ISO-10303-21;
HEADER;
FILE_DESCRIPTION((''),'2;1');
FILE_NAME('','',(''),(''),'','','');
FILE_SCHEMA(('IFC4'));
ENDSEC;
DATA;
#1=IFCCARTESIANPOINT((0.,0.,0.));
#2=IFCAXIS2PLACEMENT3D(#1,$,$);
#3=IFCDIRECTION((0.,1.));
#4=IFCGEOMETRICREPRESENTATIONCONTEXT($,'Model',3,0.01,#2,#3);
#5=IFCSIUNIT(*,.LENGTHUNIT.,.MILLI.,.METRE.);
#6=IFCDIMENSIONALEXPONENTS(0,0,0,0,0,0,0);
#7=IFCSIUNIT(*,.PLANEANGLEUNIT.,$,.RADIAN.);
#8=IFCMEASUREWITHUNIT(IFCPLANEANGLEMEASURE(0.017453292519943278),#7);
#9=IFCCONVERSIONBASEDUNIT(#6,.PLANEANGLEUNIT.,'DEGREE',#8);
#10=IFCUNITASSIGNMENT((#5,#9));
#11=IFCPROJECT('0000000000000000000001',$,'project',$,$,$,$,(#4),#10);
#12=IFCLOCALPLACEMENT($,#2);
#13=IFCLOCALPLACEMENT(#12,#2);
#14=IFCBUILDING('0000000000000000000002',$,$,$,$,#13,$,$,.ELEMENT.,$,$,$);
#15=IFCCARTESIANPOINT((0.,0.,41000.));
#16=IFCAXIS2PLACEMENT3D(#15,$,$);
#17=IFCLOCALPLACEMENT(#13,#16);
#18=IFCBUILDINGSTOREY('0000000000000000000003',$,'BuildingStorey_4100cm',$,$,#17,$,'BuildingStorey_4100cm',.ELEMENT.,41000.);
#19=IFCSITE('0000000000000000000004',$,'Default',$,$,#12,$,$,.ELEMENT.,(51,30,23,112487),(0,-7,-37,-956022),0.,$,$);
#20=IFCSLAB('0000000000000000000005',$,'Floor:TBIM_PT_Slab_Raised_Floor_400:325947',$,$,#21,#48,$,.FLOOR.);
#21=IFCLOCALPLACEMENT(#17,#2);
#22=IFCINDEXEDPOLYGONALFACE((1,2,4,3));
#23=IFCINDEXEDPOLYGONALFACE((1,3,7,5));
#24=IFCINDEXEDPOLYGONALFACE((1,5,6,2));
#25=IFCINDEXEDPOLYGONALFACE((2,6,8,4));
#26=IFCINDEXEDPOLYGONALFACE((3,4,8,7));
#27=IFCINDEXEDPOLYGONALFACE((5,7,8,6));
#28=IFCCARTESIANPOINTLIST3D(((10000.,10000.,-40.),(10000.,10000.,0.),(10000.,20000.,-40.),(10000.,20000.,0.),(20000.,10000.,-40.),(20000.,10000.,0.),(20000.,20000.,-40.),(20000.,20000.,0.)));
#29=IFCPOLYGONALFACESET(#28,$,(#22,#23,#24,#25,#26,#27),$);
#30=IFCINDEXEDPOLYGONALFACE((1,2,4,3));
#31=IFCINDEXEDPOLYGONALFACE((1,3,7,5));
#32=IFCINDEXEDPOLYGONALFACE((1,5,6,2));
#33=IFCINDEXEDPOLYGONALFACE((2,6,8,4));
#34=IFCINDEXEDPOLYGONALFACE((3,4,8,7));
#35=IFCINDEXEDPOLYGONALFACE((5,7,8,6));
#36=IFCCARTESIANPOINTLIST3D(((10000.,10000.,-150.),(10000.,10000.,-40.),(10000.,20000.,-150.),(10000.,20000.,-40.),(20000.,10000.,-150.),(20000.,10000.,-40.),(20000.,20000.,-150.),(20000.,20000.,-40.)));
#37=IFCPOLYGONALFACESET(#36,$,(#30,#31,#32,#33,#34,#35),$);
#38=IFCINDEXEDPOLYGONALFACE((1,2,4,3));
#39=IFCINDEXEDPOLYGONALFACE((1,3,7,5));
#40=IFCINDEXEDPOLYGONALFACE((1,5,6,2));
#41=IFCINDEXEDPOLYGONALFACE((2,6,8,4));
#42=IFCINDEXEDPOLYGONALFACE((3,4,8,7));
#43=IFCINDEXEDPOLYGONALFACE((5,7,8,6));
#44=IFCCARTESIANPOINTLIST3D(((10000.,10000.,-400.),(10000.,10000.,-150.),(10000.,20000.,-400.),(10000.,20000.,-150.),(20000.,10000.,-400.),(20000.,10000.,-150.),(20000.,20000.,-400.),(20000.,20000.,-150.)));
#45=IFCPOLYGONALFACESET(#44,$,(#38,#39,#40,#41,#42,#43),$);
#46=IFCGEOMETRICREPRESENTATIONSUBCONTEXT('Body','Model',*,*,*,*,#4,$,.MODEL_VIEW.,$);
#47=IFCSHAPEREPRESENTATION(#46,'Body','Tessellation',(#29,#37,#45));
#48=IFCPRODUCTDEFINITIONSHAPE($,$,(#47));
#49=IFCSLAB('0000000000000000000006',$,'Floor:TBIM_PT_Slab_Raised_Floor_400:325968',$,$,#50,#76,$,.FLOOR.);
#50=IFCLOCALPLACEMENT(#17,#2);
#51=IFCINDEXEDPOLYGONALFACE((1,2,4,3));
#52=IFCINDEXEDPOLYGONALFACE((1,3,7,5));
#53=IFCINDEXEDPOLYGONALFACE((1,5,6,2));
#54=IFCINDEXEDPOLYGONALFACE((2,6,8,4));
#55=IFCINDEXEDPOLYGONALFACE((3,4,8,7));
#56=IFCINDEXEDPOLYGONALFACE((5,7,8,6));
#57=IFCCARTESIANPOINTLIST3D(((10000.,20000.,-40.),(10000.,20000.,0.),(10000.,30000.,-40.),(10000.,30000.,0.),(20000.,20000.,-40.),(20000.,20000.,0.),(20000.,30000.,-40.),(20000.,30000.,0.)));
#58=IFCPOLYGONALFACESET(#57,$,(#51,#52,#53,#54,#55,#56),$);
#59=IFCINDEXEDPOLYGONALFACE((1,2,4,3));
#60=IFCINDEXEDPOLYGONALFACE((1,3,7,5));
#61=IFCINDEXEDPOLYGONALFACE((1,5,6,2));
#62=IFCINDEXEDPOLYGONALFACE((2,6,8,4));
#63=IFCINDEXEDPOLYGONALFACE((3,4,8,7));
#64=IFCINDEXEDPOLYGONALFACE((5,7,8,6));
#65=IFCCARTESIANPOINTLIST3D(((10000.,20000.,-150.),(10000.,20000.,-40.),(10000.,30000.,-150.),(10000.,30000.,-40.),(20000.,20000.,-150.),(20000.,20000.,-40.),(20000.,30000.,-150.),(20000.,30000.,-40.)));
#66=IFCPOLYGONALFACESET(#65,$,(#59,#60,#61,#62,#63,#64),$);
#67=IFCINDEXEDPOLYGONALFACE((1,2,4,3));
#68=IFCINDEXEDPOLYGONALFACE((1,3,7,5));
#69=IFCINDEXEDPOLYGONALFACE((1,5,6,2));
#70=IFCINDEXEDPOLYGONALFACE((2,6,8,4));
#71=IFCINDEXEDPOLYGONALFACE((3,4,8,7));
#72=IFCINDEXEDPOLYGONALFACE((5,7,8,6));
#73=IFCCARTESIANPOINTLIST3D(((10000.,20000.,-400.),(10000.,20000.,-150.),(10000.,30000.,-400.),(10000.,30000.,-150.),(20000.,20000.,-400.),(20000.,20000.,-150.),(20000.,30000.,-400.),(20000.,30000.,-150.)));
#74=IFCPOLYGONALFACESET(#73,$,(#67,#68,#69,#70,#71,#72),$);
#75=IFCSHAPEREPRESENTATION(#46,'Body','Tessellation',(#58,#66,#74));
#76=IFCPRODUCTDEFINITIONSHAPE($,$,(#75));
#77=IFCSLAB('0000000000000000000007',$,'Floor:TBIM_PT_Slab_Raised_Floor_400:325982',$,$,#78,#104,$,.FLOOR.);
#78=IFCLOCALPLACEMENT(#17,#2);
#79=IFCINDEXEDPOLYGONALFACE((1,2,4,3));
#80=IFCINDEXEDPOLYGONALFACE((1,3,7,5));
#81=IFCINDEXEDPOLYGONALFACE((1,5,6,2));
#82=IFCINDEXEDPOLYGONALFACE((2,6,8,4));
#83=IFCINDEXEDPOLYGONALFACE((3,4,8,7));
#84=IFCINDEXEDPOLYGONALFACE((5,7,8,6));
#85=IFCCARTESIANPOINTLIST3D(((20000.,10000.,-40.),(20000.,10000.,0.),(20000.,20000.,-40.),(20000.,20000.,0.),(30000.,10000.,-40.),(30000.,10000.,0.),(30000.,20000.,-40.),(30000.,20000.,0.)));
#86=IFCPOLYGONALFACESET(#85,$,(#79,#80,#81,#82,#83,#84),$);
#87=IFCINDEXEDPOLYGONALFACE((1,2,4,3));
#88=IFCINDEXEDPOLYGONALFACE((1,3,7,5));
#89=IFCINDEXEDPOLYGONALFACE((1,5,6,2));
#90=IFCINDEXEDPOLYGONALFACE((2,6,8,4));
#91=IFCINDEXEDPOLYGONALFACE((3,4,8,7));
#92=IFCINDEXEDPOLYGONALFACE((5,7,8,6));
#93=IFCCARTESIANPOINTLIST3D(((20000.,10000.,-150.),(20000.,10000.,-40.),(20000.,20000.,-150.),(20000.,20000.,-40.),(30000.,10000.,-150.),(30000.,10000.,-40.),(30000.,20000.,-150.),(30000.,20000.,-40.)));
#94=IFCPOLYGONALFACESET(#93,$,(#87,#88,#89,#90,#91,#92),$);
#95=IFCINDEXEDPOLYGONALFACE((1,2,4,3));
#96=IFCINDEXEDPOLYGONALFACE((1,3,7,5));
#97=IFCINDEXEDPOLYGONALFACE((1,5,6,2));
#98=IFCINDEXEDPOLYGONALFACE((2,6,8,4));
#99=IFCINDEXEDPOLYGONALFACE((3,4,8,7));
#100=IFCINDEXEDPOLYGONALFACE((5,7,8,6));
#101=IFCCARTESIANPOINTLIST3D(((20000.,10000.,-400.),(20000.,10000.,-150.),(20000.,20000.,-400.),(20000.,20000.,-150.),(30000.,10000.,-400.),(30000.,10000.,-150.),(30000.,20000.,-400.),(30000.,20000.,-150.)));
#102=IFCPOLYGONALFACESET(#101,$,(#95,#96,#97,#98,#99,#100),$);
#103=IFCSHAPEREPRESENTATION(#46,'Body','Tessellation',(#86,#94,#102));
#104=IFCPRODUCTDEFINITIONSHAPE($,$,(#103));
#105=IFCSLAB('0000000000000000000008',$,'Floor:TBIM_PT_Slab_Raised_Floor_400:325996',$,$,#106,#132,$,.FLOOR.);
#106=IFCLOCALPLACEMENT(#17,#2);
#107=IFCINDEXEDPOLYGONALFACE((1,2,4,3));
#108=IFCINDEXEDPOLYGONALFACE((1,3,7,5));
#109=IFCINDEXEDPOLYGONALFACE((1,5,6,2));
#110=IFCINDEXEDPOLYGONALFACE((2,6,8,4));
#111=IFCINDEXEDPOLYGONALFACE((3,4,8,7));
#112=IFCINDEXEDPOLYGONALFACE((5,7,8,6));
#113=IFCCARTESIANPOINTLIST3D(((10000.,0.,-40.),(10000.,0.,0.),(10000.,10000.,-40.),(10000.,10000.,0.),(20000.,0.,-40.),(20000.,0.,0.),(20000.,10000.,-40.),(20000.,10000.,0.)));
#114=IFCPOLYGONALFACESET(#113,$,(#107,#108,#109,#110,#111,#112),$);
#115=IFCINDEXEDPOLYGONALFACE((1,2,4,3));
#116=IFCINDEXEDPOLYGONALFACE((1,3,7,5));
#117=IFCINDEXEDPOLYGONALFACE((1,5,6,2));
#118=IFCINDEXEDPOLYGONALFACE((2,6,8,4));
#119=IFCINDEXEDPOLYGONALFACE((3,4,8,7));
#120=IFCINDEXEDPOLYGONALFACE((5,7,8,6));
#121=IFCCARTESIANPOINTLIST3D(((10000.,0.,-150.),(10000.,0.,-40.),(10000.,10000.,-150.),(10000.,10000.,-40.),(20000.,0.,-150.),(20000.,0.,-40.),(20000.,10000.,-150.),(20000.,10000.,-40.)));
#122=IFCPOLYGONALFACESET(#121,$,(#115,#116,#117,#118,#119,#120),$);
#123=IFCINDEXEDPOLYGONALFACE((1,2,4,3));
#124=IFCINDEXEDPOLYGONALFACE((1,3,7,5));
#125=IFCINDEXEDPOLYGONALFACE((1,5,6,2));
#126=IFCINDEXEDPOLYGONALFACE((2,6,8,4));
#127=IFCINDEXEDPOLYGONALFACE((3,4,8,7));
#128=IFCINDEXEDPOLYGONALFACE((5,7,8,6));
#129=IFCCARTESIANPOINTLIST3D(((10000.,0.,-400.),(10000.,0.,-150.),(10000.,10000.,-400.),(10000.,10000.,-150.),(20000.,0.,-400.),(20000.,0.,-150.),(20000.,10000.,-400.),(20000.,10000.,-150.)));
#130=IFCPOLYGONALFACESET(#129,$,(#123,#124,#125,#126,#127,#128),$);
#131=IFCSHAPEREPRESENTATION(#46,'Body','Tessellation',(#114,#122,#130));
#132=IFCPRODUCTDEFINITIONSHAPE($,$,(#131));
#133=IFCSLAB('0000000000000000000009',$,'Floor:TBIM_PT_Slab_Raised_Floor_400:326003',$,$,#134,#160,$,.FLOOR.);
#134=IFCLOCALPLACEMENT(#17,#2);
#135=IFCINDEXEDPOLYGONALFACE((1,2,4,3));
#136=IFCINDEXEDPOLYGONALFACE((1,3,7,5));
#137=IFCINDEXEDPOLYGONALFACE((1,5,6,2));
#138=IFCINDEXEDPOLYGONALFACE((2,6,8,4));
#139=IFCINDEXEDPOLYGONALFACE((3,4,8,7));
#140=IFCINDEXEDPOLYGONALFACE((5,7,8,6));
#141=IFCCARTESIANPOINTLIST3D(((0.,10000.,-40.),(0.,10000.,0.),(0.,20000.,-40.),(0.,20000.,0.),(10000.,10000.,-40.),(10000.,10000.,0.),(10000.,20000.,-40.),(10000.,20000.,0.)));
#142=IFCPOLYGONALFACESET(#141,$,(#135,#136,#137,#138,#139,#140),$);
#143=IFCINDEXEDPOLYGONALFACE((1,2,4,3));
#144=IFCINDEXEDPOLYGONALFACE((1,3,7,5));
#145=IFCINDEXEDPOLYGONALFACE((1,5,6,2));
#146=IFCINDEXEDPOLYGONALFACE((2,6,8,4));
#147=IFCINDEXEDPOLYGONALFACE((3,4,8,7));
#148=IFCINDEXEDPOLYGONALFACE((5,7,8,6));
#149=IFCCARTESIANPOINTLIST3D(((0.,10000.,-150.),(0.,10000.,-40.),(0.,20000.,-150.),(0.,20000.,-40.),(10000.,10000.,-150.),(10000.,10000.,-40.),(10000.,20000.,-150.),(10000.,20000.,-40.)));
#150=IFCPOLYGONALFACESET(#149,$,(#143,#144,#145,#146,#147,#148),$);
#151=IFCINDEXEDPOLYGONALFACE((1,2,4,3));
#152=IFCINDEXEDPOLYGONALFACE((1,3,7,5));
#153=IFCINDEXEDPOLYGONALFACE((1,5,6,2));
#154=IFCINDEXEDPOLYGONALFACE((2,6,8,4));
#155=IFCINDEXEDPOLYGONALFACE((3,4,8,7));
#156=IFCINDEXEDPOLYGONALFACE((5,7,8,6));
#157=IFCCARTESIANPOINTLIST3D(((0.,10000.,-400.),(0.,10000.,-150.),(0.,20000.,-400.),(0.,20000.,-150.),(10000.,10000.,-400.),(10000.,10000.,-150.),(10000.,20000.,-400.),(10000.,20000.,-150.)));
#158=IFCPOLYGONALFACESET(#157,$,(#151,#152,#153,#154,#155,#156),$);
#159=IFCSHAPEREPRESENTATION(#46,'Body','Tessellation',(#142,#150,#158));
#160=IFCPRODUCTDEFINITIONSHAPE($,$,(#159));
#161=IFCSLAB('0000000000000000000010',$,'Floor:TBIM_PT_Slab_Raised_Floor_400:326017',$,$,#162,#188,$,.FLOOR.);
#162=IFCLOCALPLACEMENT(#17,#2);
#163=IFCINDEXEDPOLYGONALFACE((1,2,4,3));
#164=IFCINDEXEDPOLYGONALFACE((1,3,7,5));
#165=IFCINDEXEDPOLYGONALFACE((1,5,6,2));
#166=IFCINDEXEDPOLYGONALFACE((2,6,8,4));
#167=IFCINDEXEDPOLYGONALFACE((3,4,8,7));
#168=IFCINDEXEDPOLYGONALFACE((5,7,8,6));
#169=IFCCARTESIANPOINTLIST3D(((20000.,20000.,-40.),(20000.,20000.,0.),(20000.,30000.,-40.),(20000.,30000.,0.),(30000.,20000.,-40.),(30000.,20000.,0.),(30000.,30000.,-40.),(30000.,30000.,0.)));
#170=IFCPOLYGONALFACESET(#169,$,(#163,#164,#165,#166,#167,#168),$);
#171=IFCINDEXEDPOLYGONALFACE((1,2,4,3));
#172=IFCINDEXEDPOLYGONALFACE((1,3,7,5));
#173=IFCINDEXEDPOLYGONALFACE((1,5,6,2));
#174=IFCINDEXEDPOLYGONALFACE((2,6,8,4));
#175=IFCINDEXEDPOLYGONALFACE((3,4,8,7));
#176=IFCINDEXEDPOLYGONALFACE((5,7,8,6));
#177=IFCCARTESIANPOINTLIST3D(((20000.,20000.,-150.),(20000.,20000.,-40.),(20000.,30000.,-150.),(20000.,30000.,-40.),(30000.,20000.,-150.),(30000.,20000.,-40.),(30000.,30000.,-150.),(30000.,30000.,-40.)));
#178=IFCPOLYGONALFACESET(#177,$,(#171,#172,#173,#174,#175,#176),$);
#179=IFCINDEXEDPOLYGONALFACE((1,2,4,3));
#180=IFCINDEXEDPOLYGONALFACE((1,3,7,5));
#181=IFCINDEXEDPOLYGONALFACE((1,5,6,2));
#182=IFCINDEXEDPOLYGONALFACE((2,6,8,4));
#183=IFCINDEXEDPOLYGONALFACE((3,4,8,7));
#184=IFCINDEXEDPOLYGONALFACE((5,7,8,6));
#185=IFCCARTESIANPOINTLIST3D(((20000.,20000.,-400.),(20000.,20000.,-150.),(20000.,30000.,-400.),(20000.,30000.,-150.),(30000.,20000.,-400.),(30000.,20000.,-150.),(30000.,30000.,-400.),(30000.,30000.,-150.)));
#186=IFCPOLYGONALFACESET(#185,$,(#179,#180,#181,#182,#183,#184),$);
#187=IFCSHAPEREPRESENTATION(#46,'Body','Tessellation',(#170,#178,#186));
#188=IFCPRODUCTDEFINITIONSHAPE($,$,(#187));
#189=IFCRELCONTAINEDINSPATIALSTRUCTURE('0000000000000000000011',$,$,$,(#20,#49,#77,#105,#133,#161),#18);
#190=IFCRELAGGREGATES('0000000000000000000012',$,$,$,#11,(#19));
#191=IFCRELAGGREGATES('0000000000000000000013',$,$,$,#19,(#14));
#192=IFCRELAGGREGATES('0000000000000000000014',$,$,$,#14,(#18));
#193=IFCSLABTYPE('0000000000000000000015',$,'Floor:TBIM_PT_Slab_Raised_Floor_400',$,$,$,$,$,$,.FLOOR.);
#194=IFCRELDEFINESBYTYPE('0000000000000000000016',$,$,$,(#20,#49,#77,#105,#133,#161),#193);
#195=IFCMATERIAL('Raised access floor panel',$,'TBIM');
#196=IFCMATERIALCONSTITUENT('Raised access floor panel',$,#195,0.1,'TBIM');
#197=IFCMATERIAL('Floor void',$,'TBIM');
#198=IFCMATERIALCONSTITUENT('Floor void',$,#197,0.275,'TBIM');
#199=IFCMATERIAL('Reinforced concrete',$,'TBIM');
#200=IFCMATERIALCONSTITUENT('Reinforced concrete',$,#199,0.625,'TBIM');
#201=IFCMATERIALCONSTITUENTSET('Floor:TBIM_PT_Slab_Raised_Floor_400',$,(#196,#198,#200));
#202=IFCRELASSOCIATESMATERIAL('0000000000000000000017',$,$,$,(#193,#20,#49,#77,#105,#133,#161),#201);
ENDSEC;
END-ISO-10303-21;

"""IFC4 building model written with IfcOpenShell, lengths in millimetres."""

from ifc_helpers import new_model, entity, si_unit, converted_unit, direction, frame, origin, place, context, subcontext, project, spatial, indexed_curve, outline, extrude, material, constituent, constituent_set, type_object, element, save


model = new_model("IFC4")

# Units and contexts
model_context = context("Model", 3, precision=0.01, world=origin(), true_north=direction((0.0, 1.0)))
body_context = subcontext(model_context, "Body", "Model", "MODEL_VIEW")
ifc_project = project(units=[si_unit("LENGTHUNIT", "METRE", prefix="MILLI"), converted_unit("PLANEANGLEUNIT", "DEGREE", entity("IfcPlaneAngleMeasure", 0.017453292519943278), si_unit("PLANEANGLEUNIT", "RADIAN"), dimensions=[0, 0, 0, 0, 0, 0, 0])], contexts=[model_context])

# Site, building, storey
site_placement = place(None, origin())
site = spatial("IfcSite", under=ifc_project, at=site_placement, Name="Default", CompositionType="ELEMENT", RefLatitude=(51, 30, 23, 112487), RefLongitude=(0, -7, -37, -956022), RefElevation=0.0)
building_placement = place(site_placement, origin())
building = spatial("IfcBuilding", under=site, at=building_placement, CompositionType="ELEMENT")
storey_placement = place(building_placement, frame((0.0, 0.0, 41000.0)))
storey = spatial("IfcBuildingStorey", under=building, at=storey_placement, Name="BuildingStorey_4100cm", LongName="BuildingStorey_4100cm", CompositionType="ELEMENT", Elevation=41000.0)

# Slabs
ifc_material_1 = material(Name="Raised access floor panel", Category="TBIM")
ifc_constituent_1 = constituent(ifc_material_1, Name="Raised access floor panel", Category="TBIM", fraction=0.1)
ifc_material_2 = material(Name="Floor void", Category="TBIM")
ifc_constituent_2 = constituent(ifc_material_2, Name="Floor void", Category="TBIM", fraction=0.275)
ifc_material_3 = material(Name="Reinforced concrete", Category="TBIM")
ifc_constituent_3 = constituent(ifc_material_3, Name="Reinforced concrete", Category="TBIM", fraction=0.625)
ifc_constituent_set_1 = constituent_set(constituents=[ifc_constituent_1, ifc_constituent_2, ifc_constituent_3], Name="Floor:TBIM_PT_Slab_Raised_Floor_400")
slab_type = type_object("IfcSlabType", Name="Floor:TBIM_PT_Slab_Raised_Floor_400", PredefinedType="FLOOR", material=ifc_constituent_set_1)
slab_1_placement = place(storey_placement, origin())
element("IfcSlab", 1, at=slab_1_placement, inside=storey, type_object=slab_type, material=ifc_constituent_set_1, Name="Floor:TBIM_PT_Slab_Raised_Floor_400:325947", PredefinedType="FLOOR", context=body_context, shape_type="SweptSolid", body=[
    extrude(outline(indexed_curve([(-5000.0, -5000.0), (5000.0, -5000.0), (5000.0, 5000.0), (-5000.0, 5000.0), (-5000.0, -5000.0)], self_intersect=False)), frame((15000.0, 15000.0, -40.0), z_axis=(0.0, 0.0, 1.0), x_axis=(-1.0, 0.0, 0.0)), (0.0, 0.0, 1.0), 40.0),
    extrude(outline(indexed_curve([(-5000.0, -5000.0), (5000.0, -5000.0), (5000.0, 5000.0), (-5000.0, 5000.0), (-5000.0, -5000.0)], self_intersect=False)), frame((15000.0, 15000.0, -150.0), z_axis=(0.0, 0.0, 1.0), x_axis=(-1.0, 0.0, 0.0)), (0.0, 0.0, 1.0), 110.0),
    extrude(outline(indexed_curve([(-5000.0, -5000.0), (5000.0, -5000.0), (5000.0, 5000.0), (-5000.0, 5000.0), (-5000.0, -5000.0)], self_intersect=False)), frame((15000.0, 15000.0, -400.0), z_axis=(0.0, 0.0, 1.0), x_axis=(-1.0, 0.0, 0.0)), (0.0, 0.0, 1.0), 250.0),
])
slab_2_placement = place(storey_placement, origin())
element("IfcSlab", 2, at=slab_2_placement, inside=storey, type_object=slab_type, material=ifc_constituent_set_1, Name="Floor:TBIM_PT_Slab_Raised_Floor_400:325968", PredefinedType="FLOOR", context=body_context, shape_type="SweptSolid", body=[
    extrude(outline(indexed_curve([(-5000.0, -5000.0), (5000.0, -5000.0), (5000.0, 5000.0), (-5000.0, 5000.0), (-5000.0, -5000.0)], self_intersect=False)), frame((15000.0, 25000.0, -40.0), z_axis=(0.0, 0.0, 1.0), x_axis=(-1.0, 0.0, 0.0)), (0.0, 0.0, 1.0), 40.0),
    extrude(outline(indexed_curve([(-5000.0, -5000.0), (5000.0, -5000.0), (5000.0, 5000.0), (-5000.0, 5000.0), (-5000.0, -5000.0)], self_intersect=False)), frame((15000.0, 25000.0, -150.0), z_axis=(0.0, 0.0, 1.0), x_axis=(-1.0, 0.0, 0.0)), (0.0, 0.0, 1.0), 110.0),
    extrude(outline(indexed_curve([(-5000.0, -5000.0), (5000.0, -5000.0), (5000.0, 5000.0), (-5000.0, 5000.0), (-5000.0, -5000.0)], self_intersect=False)), frame((15000.0, 25000.0, -400.0), z_axis=(0.0, 0.0, 1.0), x_axis=(-1.0, 0.0, 0.0)), (0.0, 0.0, 1.0), 250.0),
])
slab_3_placement = place(storey_placement, origin())
element("IfcSlab", 3, at=slab_3_placement, inside=storey, type_object=slab_type, material=ifc_constituent_set_1, Name="Floor:TBIM_PT_Slab_Raised_Floor_400:325982", PredefinedType="FLOOR", context=body_context, shape_type="SweptSolid", body=[
    extrude(outline(indexed_curve([(-5000.0, -5000.0), (5000.0, -5000.0), (5000.0, 5000.0), (-5000.0, 5000.0), (-5000.0, -5000.0)], self_intersect=False)), frame((25000.0, 15000.0, -40.0), z_axis=(0.0, 0.0, 1.0), x_axis=(-1.0, 0.0, 0.0)), (0.0, 0.0, 1.0), 40.0),
    extrude(outline(indexed_curve([(-5000.0, -5000.0), (5000.0, -5000.0), (5000.0, 5000.0), (-5000.0, 5000.0), (-5000.0, -5000.0)], self_intersect=False)), frame((25000.0, 15000.0, -150.0), z_axis=(0.0, 0.0, 1.0), x_axis=(-1.0, 0.0, 0.0)), (0.0, 0.0, 1.0), 110.0),
    extrude(outline(indexed_curve([(-5000.0, -5000.0), (5000.0, -5000.0), (5000.0, 5000.0), (-5000.0, 5000.0), (-5000.0, -5000.0)], self_intersect=False)), frame((25000.0, 15000.0, -400.0), z_axis=(0.0, 0.0, 1.0), x_axis=(-1.0, 0.0, 0.0)), (0.0, 0.0, 1.0), 250.0),
])
slab_4_placement = place(storey_placement, origin())
element("IfcSlab", 4, at=slab_4_placement, inside=storey, type_object=slab_type, material=ifc_constituent_set_1, Name="Floor:TBIM_PT_Slab_Raised_Floor_400:325996", PredefinedType="FLOOR", context=body_context, shape_type="SweptSolid", body=[
    extrude(outline(indexed_curve([(-5000.0, -5000.0), (5000.0, -5000.0), (5000.0, 5000.0), (-5000.0, 5000.0), (-5000.0, -5000.0)], self_intersect=False)), frame((15000.0, 5000.0, -40.0), z_axis=(0.0, 0.0, 1.0), x_axis=(0.0, 1.0, 0.0)), (0.0, 0.0, 1.0), 40.0),
    extrude(outline(indexed_curve([(-5000.0, -5000.0), (5000.0, -5000.0), (5000.0, 5000.0), (-5000.0, 5000.0), (-5000.0, -5000.0)], self_intersect=False)), frame((15000.0, 5000.0, -150.0), z_axis=(0.0, 0.0, 1.0), x_axis=(0.0, 1.0, 0.0)), (0.0, 0.0, 1.0), 110.0),
    extrude(outline(indexed_curve([(-5000.0, -5000.0), (5000.0, -5000.0), (5000.0, 5000.0), (-5000.0, 5000.0), (-5000.0, -5000.0)], self_intersect=False)), frame((15000.0, 5000.0, -400.0), z_axis=(0.0, 0.0, 1.0), x_axis=(0.0, 1.0, 0.0)), (0.0, 0.0, 1.0), 250.0),
])
slab_5_placement = place(storey_placement, origin())
element("IfcSlab", 5, at=slab_5_placement, inside=storey, type_object=slab_type, material=ifc_constituent_set_1, Name="Floor:TBIM_PT_Slab_Raised_Floor_400:326003", PredefinedType="FLOOR", context=body_context, shape_type="SweptSolid", body=[
    extrude(outline(indexed_curve([(-5000.0, -5000.0), (5000.0, -5000.0), (5000.0, 5000.0), (-5000.0, 5000.0), (-5000.0, -5000.0)], self_intersect=False)), frame((5000.0, 15000.0, -40.0), z_axis=(0.0, 0.0, 1.0), x_axis=(0.0, 1.0, 0.0)), (0.0, 0.0, 1.0), 40.0),
    extrude(outline(indexed_curve([(-5000.0, -5000.0), (5000.0, -5000.0), (5000.0, 5000.0), (-5000.0, 5000.0), (-5000.0, -5000.0)], self_intersect=False)), frame((5000.0, 15000.0, -150.0), z_axis=(0.0, 0.0, 1.0), x_axis=(0.0, 1.0, 0.0)), (0.0, 0.0, 1.0), 110.0),
    extrude(outline(indexed_curve([(-5000.0, -5000.0), (5000.0, -5000.0), (5000.0, 5000.0), (-5000.0, 5000.0), (-5000.0, -5000.0)], self_intersect=False)), frame((5000.0, 15000.0, -400.0), z_axis=(0.0, 0.0, 1.0), x_axis=(0.0, 1.0, 0.0)), (0.0, 0.0, 1.0), 250.0),
])
slab_6_placement = place(storey_placement, origin())
element("IfcSlab", 6, at=slab_6_placement, inside=storey, type_object=slab_type, material=ifc_constituent_set_1, Name="Floor:TBIM_PT_Slab_Raised_Floor_400:326017", PredefinedType="FLOOR", context=body_context, shape_type="SweptSolid", body=[
    extrude(outline(indexed_curve([(-5000.0, -5000.0), (5000.0, -5000.0), (5000.0, 5000.0), (-5000.0, 5000.0), (-5000.0, -5000.0)], self_intersect=False)), frame((25000.0, 25000.0, -40.0), z_axis=(0.0, 0.0, 1.0), x_axis=(-1.0, 0.0, 0.0)), (0.0, 0.0, 1.0), 40.0),
    extrude(outline(indexed_curve([(-5000.0, -5000.0), (5000.0, -5000.0), (5000.0, 5000.0), (-5000.0, 5000.0), (-5000.0, -5000.0)], self_intersect=False)), frame((25000.0, 25000.0, -150.0), z_axis=(0.0, 0.0, 1.0), x_axis=(-1.0, 0.0, 0.0)), (0.0, 0.0, 1.0), 110.0),
    extrude(outline(indexed_curve([(-5000.0, -5000.0), (5000.0, -5000.0), (5000.0, 5000.0), (-5000.0, 5000.0), (-5000.0, -5000.0)], self_intersect=False)), frame((25000.0, 25000.0, -400.0), z_axis=(0.0, 0.0, 1.0), x_axis=(-1.0, 0.0, 0.0)), (0.0, 0.0, 1.0), 250.0),
])

save(model, "model.ifc")
